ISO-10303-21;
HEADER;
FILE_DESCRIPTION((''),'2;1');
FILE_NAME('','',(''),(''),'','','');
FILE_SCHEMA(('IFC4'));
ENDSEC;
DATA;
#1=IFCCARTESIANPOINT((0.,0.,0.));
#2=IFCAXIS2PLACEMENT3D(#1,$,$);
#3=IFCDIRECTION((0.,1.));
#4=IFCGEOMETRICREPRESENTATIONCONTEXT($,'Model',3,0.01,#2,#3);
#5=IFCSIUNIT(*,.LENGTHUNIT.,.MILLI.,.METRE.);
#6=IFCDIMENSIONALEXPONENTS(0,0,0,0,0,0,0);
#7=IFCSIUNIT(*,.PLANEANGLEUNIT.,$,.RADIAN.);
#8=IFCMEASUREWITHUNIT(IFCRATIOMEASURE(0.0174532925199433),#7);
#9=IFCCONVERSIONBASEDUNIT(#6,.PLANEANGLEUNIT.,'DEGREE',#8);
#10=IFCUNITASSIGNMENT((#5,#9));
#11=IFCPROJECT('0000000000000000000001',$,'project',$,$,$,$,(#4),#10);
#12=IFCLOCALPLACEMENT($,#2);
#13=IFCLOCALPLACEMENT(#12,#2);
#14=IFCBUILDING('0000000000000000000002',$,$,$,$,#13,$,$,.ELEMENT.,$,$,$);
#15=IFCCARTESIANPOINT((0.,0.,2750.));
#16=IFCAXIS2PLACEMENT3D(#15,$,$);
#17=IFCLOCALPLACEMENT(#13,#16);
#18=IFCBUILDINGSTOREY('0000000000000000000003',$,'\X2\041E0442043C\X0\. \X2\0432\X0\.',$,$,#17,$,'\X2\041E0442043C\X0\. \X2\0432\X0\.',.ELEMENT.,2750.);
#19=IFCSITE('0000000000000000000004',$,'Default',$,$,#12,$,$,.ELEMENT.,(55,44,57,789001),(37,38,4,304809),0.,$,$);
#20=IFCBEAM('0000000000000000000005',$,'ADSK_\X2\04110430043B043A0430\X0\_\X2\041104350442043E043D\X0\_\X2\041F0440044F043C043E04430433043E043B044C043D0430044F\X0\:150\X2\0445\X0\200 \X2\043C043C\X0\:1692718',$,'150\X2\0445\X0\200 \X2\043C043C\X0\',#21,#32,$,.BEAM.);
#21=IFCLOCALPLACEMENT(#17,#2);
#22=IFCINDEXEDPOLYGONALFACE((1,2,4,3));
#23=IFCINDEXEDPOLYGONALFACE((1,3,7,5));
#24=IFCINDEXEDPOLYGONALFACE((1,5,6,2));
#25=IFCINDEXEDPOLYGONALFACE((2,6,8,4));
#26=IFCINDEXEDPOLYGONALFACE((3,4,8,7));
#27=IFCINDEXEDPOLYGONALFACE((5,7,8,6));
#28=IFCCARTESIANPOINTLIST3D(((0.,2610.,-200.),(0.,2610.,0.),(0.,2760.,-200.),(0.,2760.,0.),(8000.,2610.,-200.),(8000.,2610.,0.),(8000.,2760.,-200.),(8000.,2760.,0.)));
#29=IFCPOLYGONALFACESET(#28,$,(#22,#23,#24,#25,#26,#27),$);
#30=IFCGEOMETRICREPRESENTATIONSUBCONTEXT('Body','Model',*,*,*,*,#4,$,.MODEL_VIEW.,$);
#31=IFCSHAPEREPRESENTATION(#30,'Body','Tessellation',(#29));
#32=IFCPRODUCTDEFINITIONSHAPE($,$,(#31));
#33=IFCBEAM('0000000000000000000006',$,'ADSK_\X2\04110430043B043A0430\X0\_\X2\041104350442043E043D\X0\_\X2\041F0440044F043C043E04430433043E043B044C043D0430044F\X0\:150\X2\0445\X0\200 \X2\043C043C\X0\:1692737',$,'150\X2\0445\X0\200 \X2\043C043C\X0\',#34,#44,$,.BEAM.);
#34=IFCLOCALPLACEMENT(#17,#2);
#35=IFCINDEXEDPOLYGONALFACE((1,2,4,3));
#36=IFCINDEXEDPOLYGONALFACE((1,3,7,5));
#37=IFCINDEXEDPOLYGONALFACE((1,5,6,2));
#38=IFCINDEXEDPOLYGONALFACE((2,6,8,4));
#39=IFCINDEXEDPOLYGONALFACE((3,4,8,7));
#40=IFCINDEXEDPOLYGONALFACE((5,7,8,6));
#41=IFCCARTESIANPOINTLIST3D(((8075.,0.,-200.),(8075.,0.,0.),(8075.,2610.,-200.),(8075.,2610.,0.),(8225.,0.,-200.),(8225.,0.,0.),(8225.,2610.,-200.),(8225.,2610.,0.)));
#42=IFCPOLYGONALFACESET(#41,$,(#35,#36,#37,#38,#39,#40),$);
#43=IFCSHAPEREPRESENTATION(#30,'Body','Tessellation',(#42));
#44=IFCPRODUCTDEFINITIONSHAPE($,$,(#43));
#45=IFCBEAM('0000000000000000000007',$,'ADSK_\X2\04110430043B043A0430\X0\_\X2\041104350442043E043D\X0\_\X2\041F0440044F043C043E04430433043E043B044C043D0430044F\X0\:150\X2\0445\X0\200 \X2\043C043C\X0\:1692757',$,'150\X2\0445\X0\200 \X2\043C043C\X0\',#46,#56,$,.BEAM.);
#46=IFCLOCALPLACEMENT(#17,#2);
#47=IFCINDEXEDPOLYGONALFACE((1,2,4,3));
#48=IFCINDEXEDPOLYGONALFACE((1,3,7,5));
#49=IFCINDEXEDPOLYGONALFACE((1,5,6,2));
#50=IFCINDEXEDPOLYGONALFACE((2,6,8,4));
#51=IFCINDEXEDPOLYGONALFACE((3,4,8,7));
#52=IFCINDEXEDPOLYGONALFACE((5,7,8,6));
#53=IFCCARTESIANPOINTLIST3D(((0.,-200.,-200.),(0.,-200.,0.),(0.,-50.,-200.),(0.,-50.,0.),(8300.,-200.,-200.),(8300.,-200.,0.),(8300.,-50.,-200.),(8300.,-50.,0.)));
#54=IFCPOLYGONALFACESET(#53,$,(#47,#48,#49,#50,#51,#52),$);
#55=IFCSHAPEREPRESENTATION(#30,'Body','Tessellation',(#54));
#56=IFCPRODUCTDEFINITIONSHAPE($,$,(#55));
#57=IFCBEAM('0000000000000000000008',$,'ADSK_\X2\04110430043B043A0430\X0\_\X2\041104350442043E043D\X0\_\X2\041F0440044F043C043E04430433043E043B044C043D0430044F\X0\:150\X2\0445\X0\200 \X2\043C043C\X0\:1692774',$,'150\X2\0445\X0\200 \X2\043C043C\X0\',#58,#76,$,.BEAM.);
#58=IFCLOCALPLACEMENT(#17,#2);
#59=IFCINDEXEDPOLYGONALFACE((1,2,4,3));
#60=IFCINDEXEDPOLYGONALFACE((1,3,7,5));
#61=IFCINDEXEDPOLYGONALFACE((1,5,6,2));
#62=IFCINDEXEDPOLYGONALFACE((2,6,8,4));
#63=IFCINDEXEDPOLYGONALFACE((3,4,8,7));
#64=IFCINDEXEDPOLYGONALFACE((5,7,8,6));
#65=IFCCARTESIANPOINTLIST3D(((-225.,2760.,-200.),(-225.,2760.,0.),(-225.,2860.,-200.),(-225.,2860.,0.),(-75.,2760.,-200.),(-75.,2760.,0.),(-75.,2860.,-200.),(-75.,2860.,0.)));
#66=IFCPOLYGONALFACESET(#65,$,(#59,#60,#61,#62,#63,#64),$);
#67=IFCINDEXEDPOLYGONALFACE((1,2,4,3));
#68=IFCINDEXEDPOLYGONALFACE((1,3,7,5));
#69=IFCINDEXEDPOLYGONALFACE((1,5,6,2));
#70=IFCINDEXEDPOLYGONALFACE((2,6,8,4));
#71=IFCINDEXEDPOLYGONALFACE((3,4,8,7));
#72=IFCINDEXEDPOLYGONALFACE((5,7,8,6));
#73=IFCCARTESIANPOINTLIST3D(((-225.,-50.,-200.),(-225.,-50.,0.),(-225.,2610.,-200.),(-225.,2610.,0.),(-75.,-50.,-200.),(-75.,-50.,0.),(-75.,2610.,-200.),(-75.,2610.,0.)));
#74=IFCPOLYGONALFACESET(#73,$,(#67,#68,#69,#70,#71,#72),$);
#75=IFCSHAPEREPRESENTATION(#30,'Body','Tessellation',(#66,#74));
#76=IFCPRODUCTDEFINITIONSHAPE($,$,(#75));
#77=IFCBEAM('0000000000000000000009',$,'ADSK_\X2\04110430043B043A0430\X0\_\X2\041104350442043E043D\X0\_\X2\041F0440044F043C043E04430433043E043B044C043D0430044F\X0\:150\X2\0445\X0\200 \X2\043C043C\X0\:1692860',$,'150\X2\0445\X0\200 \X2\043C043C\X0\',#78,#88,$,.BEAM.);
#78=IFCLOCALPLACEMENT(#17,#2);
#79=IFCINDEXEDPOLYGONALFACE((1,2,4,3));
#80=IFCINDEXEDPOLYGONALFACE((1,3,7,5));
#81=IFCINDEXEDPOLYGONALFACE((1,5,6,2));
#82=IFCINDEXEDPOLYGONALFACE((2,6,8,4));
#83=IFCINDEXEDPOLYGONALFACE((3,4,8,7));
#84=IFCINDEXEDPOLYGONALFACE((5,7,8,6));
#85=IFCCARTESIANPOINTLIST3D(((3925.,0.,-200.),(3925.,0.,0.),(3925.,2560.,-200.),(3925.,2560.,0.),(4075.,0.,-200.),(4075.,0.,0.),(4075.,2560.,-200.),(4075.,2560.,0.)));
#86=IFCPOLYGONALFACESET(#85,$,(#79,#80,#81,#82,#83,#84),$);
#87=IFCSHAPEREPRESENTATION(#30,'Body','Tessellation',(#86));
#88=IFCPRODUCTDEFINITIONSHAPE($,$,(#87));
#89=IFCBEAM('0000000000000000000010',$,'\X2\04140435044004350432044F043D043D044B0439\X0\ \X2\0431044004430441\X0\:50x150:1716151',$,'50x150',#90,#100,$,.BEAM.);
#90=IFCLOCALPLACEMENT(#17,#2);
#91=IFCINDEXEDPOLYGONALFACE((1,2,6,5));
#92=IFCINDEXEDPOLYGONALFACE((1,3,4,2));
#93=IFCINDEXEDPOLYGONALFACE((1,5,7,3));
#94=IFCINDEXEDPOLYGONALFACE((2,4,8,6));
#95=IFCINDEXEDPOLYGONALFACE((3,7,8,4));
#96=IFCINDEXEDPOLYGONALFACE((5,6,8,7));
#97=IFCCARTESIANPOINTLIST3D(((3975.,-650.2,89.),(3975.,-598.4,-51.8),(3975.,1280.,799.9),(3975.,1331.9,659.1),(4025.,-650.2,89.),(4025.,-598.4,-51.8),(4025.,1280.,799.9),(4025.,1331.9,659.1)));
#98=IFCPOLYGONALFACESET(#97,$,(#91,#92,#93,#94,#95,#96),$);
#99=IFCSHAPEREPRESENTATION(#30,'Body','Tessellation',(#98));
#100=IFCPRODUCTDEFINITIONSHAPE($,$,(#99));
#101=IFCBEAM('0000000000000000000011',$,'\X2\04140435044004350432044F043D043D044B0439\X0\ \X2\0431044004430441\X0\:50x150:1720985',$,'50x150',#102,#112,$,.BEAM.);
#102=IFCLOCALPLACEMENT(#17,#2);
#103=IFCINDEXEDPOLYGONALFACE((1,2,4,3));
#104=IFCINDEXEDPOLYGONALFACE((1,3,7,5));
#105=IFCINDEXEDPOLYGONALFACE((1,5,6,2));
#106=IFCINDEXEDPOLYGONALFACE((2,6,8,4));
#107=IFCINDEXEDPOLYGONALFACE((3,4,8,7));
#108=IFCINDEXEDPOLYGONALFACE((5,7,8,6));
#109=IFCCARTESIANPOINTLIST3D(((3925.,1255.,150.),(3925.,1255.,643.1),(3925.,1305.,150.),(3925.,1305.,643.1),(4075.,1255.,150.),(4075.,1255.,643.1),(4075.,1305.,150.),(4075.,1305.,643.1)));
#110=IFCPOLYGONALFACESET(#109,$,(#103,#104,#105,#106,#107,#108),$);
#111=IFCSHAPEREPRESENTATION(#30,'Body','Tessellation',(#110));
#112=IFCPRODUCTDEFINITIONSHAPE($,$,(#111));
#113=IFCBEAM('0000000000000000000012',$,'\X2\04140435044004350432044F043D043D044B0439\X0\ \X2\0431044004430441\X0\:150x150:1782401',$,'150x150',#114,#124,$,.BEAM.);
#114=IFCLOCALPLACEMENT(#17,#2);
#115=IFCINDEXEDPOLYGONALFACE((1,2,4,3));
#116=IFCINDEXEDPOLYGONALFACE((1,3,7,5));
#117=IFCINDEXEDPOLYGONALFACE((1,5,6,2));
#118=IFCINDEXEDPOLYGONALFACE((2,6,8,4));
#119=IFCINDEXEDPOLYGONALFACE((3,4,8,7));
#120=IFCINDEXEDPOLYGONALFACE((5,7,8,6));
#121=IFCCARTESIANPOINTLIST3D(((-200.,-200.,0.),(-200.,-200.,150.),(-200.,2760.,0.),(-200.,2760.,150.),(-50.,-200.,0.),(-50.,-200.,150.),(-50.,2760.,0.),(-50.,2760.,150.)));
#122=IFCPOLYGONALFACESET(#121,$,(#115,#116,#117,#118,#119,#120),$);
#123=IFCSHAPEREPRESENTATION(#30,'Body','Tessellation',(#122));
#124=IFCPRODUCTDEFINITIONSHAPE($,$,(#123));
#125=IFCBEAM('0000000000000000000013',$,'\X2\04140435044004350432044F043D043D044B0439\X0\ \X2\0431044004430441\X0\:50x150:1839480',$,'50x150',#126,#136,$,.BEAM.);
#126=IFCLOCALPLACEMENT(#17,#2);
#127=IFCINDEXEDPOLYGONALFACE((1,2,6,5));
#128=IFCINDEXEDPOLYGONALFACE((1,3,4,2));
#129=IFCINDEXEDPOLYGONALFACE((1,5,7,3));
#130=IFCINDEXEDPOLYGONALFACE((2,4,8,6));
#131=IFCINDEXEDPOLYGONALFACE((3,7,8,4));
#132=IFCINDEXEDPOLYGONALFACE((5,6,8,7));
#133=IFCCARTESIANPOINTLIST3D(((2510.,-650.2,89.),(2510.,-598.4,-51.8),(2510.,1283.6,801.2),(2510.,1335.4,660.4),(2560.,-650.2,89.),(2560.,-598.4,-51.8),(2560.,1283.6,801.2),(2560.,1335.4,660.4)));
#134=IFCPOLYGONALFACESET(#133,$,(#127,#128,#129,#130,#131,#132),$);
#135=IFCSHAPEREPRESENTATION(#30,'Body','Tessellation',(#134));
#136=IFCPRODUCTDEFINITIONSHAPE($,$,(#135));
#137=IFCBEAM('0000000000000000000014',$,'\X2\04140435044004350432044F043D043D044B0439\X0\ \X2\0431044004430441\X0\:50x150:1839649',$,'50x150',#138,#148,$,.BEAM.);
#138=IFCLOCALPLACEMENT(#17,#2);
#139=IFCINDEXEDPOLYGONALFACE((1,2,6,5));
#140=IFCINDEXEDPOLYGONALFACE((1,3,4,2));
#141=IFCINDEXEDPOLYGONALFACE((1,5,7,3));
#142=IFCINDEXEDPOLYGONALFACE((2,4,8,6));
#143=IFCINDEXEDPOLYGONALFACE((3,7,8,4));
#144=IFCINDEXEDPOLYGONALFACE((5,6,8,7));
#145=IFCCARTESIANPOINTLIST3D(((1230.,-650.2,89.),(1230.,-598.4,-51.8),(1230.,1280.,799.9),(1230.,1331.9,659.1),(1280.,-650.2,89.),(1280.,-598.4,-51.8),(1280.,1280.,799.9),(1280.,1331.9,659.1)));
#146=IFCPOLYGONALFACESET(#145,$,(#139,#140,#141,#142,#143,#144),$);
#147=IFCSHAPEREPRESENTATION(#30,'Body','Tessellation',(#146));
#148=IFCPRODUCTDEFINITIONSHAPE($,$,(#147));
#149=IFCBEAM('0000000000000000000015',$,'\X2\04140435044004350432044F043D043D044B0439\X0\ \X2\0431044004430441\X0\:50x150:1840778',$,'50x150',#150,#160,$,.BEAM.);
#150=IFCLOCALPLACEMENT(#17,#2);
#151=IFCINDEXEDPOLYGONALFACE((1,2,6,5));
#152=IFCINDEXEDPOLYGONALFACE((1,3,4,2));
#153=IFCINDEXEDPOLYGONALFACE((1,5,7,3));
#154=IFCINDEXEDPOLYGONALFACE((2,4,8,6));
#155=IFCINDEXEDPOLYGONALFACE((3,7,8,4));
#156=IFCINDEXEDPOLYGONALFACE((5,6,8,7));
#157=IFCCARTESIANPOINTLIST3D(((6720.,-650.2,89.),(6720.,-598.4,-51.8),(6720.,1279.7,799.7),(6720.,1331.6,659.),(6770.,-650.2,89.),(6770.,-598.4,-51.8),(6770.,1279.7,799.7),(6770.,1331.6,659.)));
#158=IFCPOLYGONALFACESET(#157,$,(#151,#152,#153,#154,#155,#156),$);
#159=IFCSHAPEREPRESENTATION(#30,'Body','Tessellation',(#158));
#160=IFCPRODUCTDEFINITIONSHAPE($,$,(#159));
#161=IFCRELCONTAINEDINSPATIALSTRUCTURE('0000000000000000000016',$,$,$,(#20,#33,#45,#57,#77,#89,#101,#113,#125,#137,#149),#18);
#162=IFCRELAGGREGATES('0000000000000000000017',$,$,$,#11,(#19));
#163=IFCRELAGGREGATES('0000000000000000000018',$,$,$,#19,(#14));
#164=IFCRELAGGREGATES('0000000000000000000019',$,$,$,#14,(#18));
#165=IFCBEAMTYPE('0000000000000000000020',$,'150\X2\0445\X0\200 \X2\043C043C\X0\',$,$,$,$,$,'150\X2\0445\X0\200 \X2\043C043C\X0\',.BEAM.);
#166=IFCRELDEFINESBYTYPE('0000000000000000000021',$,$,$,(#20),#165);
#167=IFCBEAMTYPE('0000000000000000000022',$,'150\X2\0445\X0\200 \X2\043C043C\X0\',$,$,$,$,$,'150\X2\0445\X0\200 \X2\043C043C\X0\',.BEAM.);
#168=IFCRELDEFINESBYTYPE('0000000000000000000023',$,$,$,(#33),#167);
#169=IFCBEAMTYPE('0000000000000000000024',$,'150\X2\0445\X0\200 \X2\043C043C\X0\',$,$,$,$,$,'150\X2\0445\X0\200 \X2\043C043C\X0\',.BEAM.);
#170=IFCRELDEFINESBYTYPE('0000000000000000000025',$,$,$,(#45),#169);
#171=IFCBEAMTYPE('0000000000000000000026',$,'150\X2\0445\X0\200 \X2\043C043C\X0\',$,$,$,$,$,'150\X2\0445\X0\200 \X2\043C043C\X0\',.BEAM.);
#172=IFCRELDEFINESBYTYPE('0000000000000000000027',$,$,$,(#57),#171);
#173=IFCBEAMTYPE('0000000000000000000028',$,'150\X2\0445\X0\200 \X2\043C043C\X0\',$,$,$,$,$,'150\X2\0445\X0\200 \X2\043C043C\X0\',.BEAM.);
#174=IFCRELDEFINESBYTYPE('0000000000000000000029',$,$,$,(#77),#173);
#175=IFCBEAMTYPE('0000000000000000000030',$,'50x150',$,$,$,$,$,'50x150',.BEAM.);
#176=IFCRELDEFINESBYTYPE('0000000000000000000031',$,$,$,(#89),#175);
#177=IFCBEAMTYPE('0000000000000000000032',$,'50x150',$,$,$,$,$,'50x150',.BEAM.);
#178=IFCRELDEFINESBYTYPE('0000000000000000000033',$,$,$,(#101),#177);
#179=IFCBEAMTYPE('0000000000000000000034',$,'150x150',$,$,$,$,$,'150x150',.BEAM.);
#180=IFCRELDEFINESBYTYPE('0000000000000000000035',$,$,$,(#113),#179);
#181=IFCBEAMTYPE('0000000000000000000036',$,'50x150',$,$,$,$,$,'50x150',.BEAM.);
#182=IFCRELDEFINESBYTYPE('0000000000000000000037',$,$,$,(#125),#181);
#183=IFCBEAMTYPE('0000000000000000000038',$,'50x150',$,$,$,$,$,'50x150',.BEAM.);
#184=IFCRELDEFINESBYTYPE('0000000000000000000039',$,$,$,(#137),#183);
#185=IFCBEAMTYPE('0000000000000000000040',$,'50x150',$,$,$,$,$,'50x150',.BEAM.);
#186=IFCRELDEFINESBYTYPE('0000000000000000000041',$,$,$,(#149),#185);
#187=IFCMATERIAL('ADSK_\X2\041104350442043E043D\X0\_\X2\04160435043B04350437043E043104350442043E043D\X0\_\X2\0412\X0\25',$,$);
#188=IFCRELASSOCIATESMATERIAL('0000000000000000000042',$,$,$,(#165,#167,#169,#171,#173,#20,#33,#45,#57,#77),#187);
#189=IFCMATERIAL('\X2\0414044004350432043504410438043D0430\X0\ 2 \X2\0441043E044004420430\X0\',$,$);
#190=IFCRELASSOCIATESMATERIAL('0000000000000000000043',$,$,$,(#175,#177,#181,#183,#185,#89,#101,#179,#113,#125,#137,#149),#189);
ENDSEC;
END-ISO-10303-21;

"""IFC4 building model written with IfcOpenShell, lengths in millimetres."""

from ifc_helpers import new_model, entity, si_unit, converted_unit, direction, frame, frame_2d, origin, origin_2d_with_axis, place, context, subcontext, project, spatial, rectangle, extrude, source, transform, mapped, material, material_profile, profile_set, profile_usage, type_object, type_shapes, element, save


model = new_model("IFC4")

# Units and contexts
model_context = context("Model", 3, precision=0.01, world=origin(), true_north=direction((0.0, 1.0)))
body_context = subcontext(model_context, "Body", "Model", "MODEL_VIEW")
ifc_project = project(units=[si_unit("LENGTHUNIT", "METRE", prefix="MILLI"), converted_unit("PLANEANGLEUNIT", "DEGREE", entity("IfcRatioMeasure", 0.0174532925199433), si_unit("PLANEANGLEUNIT", "RADIAN"), dimensions=[0, 0, 0, 0, 0, 0, 0])], contexts=[model_context])

# Site, building, storey
site_placement = place(None, origin())
site = spatial("IfcSite", under=ifc_project, at=site_placement, Name="Default", CompositionType="ELEMENT", RefLatitude=(55, 44, 57, 789001), RefLongitude=(37, 38, 4, 304809), RefElevation=0.0)
building_placement = place(site_placement, origin())
building = spatial("IfcBuilding", under=site, at=building_placement, CompositionType="ELEMENT")
storey_placement = place(building_placement, frame((0.0, 0.0, 2750.0)))
storey = spatial("IfcBuildingStorey", under=building, at=storey_placement, Name="Отм. в.", LongName="Отм. в.", CompositionType="ELEMENT", Elevation=2750.0)

# Beams
ifc_material_1 = material(Name="ADSK_Бетон_Железобетон_В25")
ifc_material_profile_1 = material_profile(ifc_material_1, rectangle(XDim=200.0, YDim=150.0, at=frame_2d((0.0, 0.0), x_axis=(1.0, 0.0))))
ifc_profile_set_1 = profile_set([ifc_material_profile_1], Name="150х200 мм")
ifc_profile_usage_1 = profile_usage(ifc_profile_set_1, cardinal=1)
beam_type_1 = type_object("IfcBeamType", Name="150х200 мм", ElementType="150х200 мм", PredefinedType="BEAM", material=ifc_profile_set_1)
shared_shape_1 = source(origin(), body_context, "Body", "SweptSolid", [
    extrude(rectangle(XDim=200.0, YDim=150.0, at=frame_2d((0.0, 0.0), x_axis=(1.0, 0.0))), frame((0.0, 2685.0, 2650.0), z_axis=(1.0, 0.0, 0.0), x_axis=(0.0, 0.0, -1.0)), (0.0, 0.0, 1.0), 8000.0),
])
type_shapes(beam_type_1, [shared_shape_1])
beam_1_placement = place(storey_placement, frame((0.0, 0.0, -2750.0)))
element("IfcBeam", 1, at=beam_1_placement, inside=storey, type_object=beam_type_1, material=ifc_profile_usage_1, Name="ADSK_Балка_Бетон_Прямоугольная:150х200 мм:1692718", ObjectType="150х200 мм", PredefinedType="BEAM", context=body_context, shape_type="MappedRepresentation", body=[
    mapped(shared_shape_1, transform((0.0, 0.0, 0.0), scale=1.0)),
])
ifc_profile_usage_2 = profile_usage(ifc_profile_set_1, cardinal=1)
beam_type_2 = type_object("IfcBeamType", Name="150х200 мм", ElementType="150х200 мм", PredefinedType="BEAM", material=ifc_profile_set_1)
shared_shape_2 = source(origin(), body_context, "Body", "SweptSolid", [
    extrude(rectangle(XDim=200.0, YDim=150.0, at=frame_2d((0.0, 0.0), x_axis=(0.0, 1.0))), frame((8150.0, 2610.0, 2650.0), z_axis=(0.0, -1.0, 0.0), x_axis=(-1.0, 0.0, 0.0)), (0.0, 0.0, 1.0), 2610.0),
])
type_shapes(beam_type_2, [shared_shape_2])
beam_2_placement = place(storey_placement, frame((0.0, 0.0, -2750.0)))
element("IfcBeam", 2, at=beam_2_placement, inside=storey, type_object=beam_type_2, material=ifc_profile_usage_2, Name="ADSK_Балка_Бетон_Прямоугольная:150х200 мм:1692737", ObjectType="150х200 мм", PredefinedType="BEAM", context=body_context, shape_type="MappedRepresentation", body=[
    mapped(shared_shape_2, transform((0.0, 0.0, 0.0), scale=1.0)),
])
ifc_profile_usage_3 = profile_usage(ifc_profile_set_1, cardinal=1)
beam_type_3 = type_object("IfcBeamType", Name="150х200 мм", ElementType="150х200 мм", PredefinedType="BEAM", material=ifc_profile_set_1)
shared_shape_3 = source(origin(), body_context, "Body", "SweptSolid", [
    extrude(rectangle(XDim=200.0, YDim=150.0, at=frame_2d((0.0, 0.0), x_axis=(1.0, 0.0))), frame((8300.0, -125.0, 2650.0), z_axis=(-1.0, 0.0, 0.0), x_axis=(0.0, 0.0, -1.0)), (0.0, 0.0, 1.0), 8300.0),
])
type_shapes(beam_type_3, [shared_shape_3])
beam_3_placement = place(storey_placement, frame((0.0, 0.0, -2750.0)))
element("IfcBeam", 3, at=beam_3_placement, inside=storey, type_object=beam_type_3, material=ifc_profile_usage_3, Name="ADSK_Балка_Бетон_Прямоугольная:150х200 мм:1692757", ObjectType="150х200 мм", PredefinedType="BEAM", context=body_context, shape_type="MappedRepresentation", body=[
    mapped(shared_shape_3, transform((0.0, 0.0, 0.0), scale=1.0)),
])
ifc_profile_usage_4 = profile_usage(ifc_profile_set_1, cardinal=1)
beam_type_4 = type_object("IfcBeamType", Name="150х200 мм", ElementType="150х200 мм", PredefinedType="BEAM", material=ifc_profile_set_1)
shared_shape_4 = source(origin(), body_context, "Body", "SweptSolid", [
    extrude(rectangle(XDim=200.0, YDim=150.0, at=frame_2d((0.0, 0.0), x_axis=(0.0, 1.0))), frame((-150.0, 2760.0, 2650.0), z_axis=(0.0, 1.0, 0.0), x_axis=(-1.0, 0.0, 0.0)), (0.0, 0.0, 1.0), 100.0),
    extrude(rectangle(XDim=200.0, YDim=150.0, at=frame_2d((0.0, 0.0), x_axis=(0.0, 1.0))), frame((-150.0, -50.0, 2650.0), z_axis=(0.0, 1.0, 0.0), x_axis=(-1.0, 0.0, 0.0)), (0.0, 0.0, 1.0), 2660.0),
])
type_shapes(beam_type_4, [shared_shape_4])
beam_4_placement = place(storey_placement, frame((0.0, 0.0, -2750.0)))
element("IfcBeam", 4, at=beam_4_placement, inside=storey, type_object=beam_type_4, material=ifc_profile_usage_4, Name="ADSK_Балка_Бетон_Прямоугольная:150х200 мм:1692774", ObjectType="150х200 мм", PredefinedType="BEAM", context=body_context, shape_type="MappedRepresentation", body=[
    mapped(shared_shape_4, transform((0.0, 0.0, 0.0), scale=1.0)),
])
ifc_profile_usage_5 = profile_usage(ifc_profile_set_1, cardinal=1)
beam_type_5 = type_object("IfcBeamType", Name="150х200 мм", ElementType="150х200 мм", PredefinedType="BEAM", material=ifc_profile_set_1)
shared_shape_5 = source(origin(), body_context, "Body", "SweptSolid", [
    extrude(rectangle(XDim=200.0, YDim=150.0, at=frame_2d((0.0, 0.0), x_axis=(0.0, 1.0))), frame((4000.0, 2560.0, 2650.0), z_axis=(0.0, -1.0, 0.0), x_axis=(-1.0, 0.0, 0.0)), (0.0, 0.0, 1.0), 2560.0),
])
type_shapes(beam_type_5, [shared_shape_5])
beam_5_placement = place(storey_placement, frame((0.0, 0.0, -2750.0)))
element("IfcBeam", 5, at=beam_5_placement, inside=storey, type_object=beam_type_5, material=ifc_profile_usage_5, Name="ADSK_Балка_Бетон_Прямоугольная:150х200 мм:1692860", ObjectType="150х200 мм", PredefinedType="BEAM", context=body_context, shape_type="MappedRepresentation", body=[
    mapped(shared_shape_5, transform((0.0, 0.0, 0.0), scale=1.0)),
])
ifc_material_2 = material(Name="Древесина 2 сорта")
ifc_material_profile_2 = material_profile(ifc_material_2, rectangle(XDim=150.0, YDim=2960.0, at=frame_2d((0.0, 0.0), x_axis=(0.0, 1.0))))
ifc_profile_set_2 = profile_set([ifc_material_profile_2], Name="150x150")
ifc_material_profile_3 = material_profile(ifc_material_2, rectangle(XDim=150.0, YDim=50.0, at=frame_2d((0.0, 0.0), x_axis=(1.0, 0.0))))
ifc_profile_set_3 = profile_set([ifc_material_profile_3], Name="50x150")
ifc_profile_usage_6 = profile_usage(ifc_profile_set_3)
beam_type_6 = type_object("IfcBeamType", Name="50x150", ElementType="50x150", PredefinedType="BEAM", material=ifc_profile_set_3)
shared_shape_6 = source(origin(), body_context, "Body", "SweptSolid", [
    extrude(rectangle(XDim=150.0, YDim=50.0, at=frame_2d((0.0, 0.0), x_axis=(1.0, 0.0))), frame((4000.0, -624.3, 2768.6), z_axis=(0.0, 0.938384, 0.345594), x_axis=(0.0, -0.345594, 0.938384)), (0.0, 0.0, 1.0), 2057.0),
])
type_shapes(beam_type_6, [shared_shape_6])
beam_6_placement = place(storey_placement, frame((0.0, 0.0, -2750.0)))
element("IfcBeam", 6, at=beam_6_placement, inside=storey, type_object=beam_type_6, material=ifc_profile_usage_6, Name="Деревянный брус:50x150:1716151", ObjectType="50x150", PredefinedType="BEAM", context=body_context, shape_type="MappedRepresentation", body=[
    mapped(shared_shape_6, transform((0.0, 0.0, 0.0), scale=1.0)),
])
ifc_profile_usage_7 = profile_usage(ifc_profile_set_3)
beam_type_7 = type_object("IfcBeamType", Name="50x150", ElementType="50x150", PredefinedType="BEAM", material=ifc_profile_set_3)
shared_shape_7 = source(origin(), body_context, "Body", "SweptSolid", [
    extrude(rectangle(XDim=50.0, YDim=150.0, at=frame_2d((0.0, 0.0), x_axis=(1.0, 0.0))), frame((4000.0, 1280.0, 3393.1), z_axis=(0.0, 0.0, -1.0), x_axis=(0.0, -1.0, 0.0)), (0.0, 0.0, 1.0), 493.1),
])
type_shapes(beam_type_7, [shared_shape_7])
beam_7_placement = place(storey_placement, frame((0.0, 0.0, -2750.0)))
element("IfcBeam", 7, at=beam_7_placement, inside=storey, type_object=beam_type_7, material=ifc_profile_usage_7, Name="Деревянный брус:50x150:1720985", ObjectType="50x150", PredefinedType="BEAM", context=body_context, shape_type="MappedRepresentation", body=[
    mapped(shared_shape_7, transform((0.0, 0.0, 0.0), scale=1.0)),
])
ifc_profile_usage_8 = profile_usage(ifc_profile_set_2)
beam_type_8 = type_object("IfcBeamType", Name="150x150", ElementType="150x150", PredefinedType="BEAM", material=ifc_profile_set_2)
shared_shape_8 = source(origin(), body_context, "Body", "SweptSolid", [
    extrude(rectangle(XDim=150.0, YDim=2960.0, at=frame_2d((0.0, 0.0), x_axis=(0.0, 1.0))), frame((0.0, 75.0, 0.0), z_axis=(0.0, -1.0, 0.0), x_axis=(-1.0, 0.0, 0.0)), (0.0, 0.0, 1.0), 150.0),
])
type_shapes(beam_type_8, [shared_shape_8])
beam_8_placement = place(storey_placement, frame((-125.0, 1280.0, 75.0), z_axis=(0.0, 0.0, 1.0), x_axis=(0.0, -1.0, 0.0)))
element("IfcBeam", 8, at=beam_8_placement, inside=storey, type_object=beam_type_8, material=ifc_profile_usage_8, Name="Деревянный брус:150x150:1782401", ObjectType="150x150", PredefinedType="BEAM", context=body_context, shape_type="MappedRepresentation", body=[
    mapped(shared_shape_8, transform((0.0, 0.0, 0.0), scale=1.0)),
])
ifc_profile_usage_9 = profile_usage(ifc_profile_set_3)
beam_type_9 = type_object("IfcBeamType", Name="50x150", ElementType="50x150", PredefinedType="BEAM", material=ifc_profile_set_3)
shared_shape_9 = source(origin(), body_context, "Body", "SweptSolid", [
    extrude(rectangle(XDim=150.0, YDim=50.0, at=origin_2d_with_axis()), frame((2535.0, -624.3, 2768.6), z_axis=(0.0, 0.938384, 0.345594), x_axis=(0.0, -0.345594, 0.938384)), (0.0, 0.0, 1.0), 2060.7),
])
type_shapes(beam_type_9, [shared_shape_9])
beam_9_placement = place(storey_placement, frame((0.0, 0.0, -2750.0)))
element("IfcBeam", 9, at=beam_9_placement, inside=storey, type_object=beam_type_9, material=ifc_profile_usage_9, Name="Деревянный брус:50x150:1839480", ObjectType="50x150", PredefinedType="BEAM", context=body_context, shape_type="MappedRepresentation", body=[
    mapped(shared_shape_9, transform((0.0, 0.0, 0.0), scale=1.0)),
])
ifc_profile_usage_10 = profile_usage(ifc_profile_set_3)
beam_type_10 = type_object("IfcBeamType", Name="50x150", ElementType="50x150", PredefinedType="BEAM", material=ifc_profile_set_3)
shared_shape_10 = source(origin(), body_context, "Body", "SweptSolid", [
    extrude(rectangle(XDim=150.0, YDim=50.0, at=frame_2d((0.0, 0.0), x_axis=(1.0, 0.0))), frame((1255.0, -624.3, 2768.6), z_axis=(0.0, 0.938384, 0.345594), x_axis=(0.0, -0.345594, 0.938384)), (0.0, 0.0, 1.0), 2057.0),
])
type_shapes(beam_type_10, [shared_shape_10])
beam_10_placement = place(storey_placement, frame((0.0, 0.0, -2750.0)))
element("IfcBeam", 10, at=beam_10_placement, inside=storey, type_object=beam_type_10, material=ifc_profile_usage_10, Name="Деревянный брус:50x150:1839649", ObjectType="50x150", PredefinedType="BEAM", context=body_context, shape_type="MappedRepresentation", body=[
    mapped(shared_shape_10, transform((0.0, 0.0, 0.0), scale=1.0)),
])
ifc_profile_usage_11 = profile_usage(ifc_profile_set_3)
beam_type_11 = type_object("IfcBeamType", Name="50x150", ElementType="50x150", PredefinedType="BEAM", material=ifc_profile_set_3)
shared_shape_11 = source(origin(), body_context, "Body", "SweptSolid", [
    extrude(rectangle(XDim=150.0, YDim=50.0, at=frame_2d((0.0, 0.0), x_axis=(1.0, 0.0))), frame((6745.0, -624.3, 2768.6), z_axis=(0.0, 0.938384, 0.345594), x_axis=(0.0, -0.345594, 0.938384)), (0.0, 0.0, 1.0), 2056.6),
])
type_shapes(beam_type_11, [shared_shape_11])
beam_11_placement = place(storey_placement, frame((0.0, 0.0, -2750.0)))
element("IfcBeam", 11, at=beam_11_placement, inside=storey, type_object=beam_type_11, material=ifc_profile_usage_11, Name="Деревянный брус:50x150:1840778", ObjectType="50x150", PredefinedType="BEAM", context=body_context, shape_type="MappedRepresentation", body=[
    mapped(shared_shape_11, transform((0.0, 0.0, 0.0), scale=1.0)),
])

save(model, "model.ifc")
